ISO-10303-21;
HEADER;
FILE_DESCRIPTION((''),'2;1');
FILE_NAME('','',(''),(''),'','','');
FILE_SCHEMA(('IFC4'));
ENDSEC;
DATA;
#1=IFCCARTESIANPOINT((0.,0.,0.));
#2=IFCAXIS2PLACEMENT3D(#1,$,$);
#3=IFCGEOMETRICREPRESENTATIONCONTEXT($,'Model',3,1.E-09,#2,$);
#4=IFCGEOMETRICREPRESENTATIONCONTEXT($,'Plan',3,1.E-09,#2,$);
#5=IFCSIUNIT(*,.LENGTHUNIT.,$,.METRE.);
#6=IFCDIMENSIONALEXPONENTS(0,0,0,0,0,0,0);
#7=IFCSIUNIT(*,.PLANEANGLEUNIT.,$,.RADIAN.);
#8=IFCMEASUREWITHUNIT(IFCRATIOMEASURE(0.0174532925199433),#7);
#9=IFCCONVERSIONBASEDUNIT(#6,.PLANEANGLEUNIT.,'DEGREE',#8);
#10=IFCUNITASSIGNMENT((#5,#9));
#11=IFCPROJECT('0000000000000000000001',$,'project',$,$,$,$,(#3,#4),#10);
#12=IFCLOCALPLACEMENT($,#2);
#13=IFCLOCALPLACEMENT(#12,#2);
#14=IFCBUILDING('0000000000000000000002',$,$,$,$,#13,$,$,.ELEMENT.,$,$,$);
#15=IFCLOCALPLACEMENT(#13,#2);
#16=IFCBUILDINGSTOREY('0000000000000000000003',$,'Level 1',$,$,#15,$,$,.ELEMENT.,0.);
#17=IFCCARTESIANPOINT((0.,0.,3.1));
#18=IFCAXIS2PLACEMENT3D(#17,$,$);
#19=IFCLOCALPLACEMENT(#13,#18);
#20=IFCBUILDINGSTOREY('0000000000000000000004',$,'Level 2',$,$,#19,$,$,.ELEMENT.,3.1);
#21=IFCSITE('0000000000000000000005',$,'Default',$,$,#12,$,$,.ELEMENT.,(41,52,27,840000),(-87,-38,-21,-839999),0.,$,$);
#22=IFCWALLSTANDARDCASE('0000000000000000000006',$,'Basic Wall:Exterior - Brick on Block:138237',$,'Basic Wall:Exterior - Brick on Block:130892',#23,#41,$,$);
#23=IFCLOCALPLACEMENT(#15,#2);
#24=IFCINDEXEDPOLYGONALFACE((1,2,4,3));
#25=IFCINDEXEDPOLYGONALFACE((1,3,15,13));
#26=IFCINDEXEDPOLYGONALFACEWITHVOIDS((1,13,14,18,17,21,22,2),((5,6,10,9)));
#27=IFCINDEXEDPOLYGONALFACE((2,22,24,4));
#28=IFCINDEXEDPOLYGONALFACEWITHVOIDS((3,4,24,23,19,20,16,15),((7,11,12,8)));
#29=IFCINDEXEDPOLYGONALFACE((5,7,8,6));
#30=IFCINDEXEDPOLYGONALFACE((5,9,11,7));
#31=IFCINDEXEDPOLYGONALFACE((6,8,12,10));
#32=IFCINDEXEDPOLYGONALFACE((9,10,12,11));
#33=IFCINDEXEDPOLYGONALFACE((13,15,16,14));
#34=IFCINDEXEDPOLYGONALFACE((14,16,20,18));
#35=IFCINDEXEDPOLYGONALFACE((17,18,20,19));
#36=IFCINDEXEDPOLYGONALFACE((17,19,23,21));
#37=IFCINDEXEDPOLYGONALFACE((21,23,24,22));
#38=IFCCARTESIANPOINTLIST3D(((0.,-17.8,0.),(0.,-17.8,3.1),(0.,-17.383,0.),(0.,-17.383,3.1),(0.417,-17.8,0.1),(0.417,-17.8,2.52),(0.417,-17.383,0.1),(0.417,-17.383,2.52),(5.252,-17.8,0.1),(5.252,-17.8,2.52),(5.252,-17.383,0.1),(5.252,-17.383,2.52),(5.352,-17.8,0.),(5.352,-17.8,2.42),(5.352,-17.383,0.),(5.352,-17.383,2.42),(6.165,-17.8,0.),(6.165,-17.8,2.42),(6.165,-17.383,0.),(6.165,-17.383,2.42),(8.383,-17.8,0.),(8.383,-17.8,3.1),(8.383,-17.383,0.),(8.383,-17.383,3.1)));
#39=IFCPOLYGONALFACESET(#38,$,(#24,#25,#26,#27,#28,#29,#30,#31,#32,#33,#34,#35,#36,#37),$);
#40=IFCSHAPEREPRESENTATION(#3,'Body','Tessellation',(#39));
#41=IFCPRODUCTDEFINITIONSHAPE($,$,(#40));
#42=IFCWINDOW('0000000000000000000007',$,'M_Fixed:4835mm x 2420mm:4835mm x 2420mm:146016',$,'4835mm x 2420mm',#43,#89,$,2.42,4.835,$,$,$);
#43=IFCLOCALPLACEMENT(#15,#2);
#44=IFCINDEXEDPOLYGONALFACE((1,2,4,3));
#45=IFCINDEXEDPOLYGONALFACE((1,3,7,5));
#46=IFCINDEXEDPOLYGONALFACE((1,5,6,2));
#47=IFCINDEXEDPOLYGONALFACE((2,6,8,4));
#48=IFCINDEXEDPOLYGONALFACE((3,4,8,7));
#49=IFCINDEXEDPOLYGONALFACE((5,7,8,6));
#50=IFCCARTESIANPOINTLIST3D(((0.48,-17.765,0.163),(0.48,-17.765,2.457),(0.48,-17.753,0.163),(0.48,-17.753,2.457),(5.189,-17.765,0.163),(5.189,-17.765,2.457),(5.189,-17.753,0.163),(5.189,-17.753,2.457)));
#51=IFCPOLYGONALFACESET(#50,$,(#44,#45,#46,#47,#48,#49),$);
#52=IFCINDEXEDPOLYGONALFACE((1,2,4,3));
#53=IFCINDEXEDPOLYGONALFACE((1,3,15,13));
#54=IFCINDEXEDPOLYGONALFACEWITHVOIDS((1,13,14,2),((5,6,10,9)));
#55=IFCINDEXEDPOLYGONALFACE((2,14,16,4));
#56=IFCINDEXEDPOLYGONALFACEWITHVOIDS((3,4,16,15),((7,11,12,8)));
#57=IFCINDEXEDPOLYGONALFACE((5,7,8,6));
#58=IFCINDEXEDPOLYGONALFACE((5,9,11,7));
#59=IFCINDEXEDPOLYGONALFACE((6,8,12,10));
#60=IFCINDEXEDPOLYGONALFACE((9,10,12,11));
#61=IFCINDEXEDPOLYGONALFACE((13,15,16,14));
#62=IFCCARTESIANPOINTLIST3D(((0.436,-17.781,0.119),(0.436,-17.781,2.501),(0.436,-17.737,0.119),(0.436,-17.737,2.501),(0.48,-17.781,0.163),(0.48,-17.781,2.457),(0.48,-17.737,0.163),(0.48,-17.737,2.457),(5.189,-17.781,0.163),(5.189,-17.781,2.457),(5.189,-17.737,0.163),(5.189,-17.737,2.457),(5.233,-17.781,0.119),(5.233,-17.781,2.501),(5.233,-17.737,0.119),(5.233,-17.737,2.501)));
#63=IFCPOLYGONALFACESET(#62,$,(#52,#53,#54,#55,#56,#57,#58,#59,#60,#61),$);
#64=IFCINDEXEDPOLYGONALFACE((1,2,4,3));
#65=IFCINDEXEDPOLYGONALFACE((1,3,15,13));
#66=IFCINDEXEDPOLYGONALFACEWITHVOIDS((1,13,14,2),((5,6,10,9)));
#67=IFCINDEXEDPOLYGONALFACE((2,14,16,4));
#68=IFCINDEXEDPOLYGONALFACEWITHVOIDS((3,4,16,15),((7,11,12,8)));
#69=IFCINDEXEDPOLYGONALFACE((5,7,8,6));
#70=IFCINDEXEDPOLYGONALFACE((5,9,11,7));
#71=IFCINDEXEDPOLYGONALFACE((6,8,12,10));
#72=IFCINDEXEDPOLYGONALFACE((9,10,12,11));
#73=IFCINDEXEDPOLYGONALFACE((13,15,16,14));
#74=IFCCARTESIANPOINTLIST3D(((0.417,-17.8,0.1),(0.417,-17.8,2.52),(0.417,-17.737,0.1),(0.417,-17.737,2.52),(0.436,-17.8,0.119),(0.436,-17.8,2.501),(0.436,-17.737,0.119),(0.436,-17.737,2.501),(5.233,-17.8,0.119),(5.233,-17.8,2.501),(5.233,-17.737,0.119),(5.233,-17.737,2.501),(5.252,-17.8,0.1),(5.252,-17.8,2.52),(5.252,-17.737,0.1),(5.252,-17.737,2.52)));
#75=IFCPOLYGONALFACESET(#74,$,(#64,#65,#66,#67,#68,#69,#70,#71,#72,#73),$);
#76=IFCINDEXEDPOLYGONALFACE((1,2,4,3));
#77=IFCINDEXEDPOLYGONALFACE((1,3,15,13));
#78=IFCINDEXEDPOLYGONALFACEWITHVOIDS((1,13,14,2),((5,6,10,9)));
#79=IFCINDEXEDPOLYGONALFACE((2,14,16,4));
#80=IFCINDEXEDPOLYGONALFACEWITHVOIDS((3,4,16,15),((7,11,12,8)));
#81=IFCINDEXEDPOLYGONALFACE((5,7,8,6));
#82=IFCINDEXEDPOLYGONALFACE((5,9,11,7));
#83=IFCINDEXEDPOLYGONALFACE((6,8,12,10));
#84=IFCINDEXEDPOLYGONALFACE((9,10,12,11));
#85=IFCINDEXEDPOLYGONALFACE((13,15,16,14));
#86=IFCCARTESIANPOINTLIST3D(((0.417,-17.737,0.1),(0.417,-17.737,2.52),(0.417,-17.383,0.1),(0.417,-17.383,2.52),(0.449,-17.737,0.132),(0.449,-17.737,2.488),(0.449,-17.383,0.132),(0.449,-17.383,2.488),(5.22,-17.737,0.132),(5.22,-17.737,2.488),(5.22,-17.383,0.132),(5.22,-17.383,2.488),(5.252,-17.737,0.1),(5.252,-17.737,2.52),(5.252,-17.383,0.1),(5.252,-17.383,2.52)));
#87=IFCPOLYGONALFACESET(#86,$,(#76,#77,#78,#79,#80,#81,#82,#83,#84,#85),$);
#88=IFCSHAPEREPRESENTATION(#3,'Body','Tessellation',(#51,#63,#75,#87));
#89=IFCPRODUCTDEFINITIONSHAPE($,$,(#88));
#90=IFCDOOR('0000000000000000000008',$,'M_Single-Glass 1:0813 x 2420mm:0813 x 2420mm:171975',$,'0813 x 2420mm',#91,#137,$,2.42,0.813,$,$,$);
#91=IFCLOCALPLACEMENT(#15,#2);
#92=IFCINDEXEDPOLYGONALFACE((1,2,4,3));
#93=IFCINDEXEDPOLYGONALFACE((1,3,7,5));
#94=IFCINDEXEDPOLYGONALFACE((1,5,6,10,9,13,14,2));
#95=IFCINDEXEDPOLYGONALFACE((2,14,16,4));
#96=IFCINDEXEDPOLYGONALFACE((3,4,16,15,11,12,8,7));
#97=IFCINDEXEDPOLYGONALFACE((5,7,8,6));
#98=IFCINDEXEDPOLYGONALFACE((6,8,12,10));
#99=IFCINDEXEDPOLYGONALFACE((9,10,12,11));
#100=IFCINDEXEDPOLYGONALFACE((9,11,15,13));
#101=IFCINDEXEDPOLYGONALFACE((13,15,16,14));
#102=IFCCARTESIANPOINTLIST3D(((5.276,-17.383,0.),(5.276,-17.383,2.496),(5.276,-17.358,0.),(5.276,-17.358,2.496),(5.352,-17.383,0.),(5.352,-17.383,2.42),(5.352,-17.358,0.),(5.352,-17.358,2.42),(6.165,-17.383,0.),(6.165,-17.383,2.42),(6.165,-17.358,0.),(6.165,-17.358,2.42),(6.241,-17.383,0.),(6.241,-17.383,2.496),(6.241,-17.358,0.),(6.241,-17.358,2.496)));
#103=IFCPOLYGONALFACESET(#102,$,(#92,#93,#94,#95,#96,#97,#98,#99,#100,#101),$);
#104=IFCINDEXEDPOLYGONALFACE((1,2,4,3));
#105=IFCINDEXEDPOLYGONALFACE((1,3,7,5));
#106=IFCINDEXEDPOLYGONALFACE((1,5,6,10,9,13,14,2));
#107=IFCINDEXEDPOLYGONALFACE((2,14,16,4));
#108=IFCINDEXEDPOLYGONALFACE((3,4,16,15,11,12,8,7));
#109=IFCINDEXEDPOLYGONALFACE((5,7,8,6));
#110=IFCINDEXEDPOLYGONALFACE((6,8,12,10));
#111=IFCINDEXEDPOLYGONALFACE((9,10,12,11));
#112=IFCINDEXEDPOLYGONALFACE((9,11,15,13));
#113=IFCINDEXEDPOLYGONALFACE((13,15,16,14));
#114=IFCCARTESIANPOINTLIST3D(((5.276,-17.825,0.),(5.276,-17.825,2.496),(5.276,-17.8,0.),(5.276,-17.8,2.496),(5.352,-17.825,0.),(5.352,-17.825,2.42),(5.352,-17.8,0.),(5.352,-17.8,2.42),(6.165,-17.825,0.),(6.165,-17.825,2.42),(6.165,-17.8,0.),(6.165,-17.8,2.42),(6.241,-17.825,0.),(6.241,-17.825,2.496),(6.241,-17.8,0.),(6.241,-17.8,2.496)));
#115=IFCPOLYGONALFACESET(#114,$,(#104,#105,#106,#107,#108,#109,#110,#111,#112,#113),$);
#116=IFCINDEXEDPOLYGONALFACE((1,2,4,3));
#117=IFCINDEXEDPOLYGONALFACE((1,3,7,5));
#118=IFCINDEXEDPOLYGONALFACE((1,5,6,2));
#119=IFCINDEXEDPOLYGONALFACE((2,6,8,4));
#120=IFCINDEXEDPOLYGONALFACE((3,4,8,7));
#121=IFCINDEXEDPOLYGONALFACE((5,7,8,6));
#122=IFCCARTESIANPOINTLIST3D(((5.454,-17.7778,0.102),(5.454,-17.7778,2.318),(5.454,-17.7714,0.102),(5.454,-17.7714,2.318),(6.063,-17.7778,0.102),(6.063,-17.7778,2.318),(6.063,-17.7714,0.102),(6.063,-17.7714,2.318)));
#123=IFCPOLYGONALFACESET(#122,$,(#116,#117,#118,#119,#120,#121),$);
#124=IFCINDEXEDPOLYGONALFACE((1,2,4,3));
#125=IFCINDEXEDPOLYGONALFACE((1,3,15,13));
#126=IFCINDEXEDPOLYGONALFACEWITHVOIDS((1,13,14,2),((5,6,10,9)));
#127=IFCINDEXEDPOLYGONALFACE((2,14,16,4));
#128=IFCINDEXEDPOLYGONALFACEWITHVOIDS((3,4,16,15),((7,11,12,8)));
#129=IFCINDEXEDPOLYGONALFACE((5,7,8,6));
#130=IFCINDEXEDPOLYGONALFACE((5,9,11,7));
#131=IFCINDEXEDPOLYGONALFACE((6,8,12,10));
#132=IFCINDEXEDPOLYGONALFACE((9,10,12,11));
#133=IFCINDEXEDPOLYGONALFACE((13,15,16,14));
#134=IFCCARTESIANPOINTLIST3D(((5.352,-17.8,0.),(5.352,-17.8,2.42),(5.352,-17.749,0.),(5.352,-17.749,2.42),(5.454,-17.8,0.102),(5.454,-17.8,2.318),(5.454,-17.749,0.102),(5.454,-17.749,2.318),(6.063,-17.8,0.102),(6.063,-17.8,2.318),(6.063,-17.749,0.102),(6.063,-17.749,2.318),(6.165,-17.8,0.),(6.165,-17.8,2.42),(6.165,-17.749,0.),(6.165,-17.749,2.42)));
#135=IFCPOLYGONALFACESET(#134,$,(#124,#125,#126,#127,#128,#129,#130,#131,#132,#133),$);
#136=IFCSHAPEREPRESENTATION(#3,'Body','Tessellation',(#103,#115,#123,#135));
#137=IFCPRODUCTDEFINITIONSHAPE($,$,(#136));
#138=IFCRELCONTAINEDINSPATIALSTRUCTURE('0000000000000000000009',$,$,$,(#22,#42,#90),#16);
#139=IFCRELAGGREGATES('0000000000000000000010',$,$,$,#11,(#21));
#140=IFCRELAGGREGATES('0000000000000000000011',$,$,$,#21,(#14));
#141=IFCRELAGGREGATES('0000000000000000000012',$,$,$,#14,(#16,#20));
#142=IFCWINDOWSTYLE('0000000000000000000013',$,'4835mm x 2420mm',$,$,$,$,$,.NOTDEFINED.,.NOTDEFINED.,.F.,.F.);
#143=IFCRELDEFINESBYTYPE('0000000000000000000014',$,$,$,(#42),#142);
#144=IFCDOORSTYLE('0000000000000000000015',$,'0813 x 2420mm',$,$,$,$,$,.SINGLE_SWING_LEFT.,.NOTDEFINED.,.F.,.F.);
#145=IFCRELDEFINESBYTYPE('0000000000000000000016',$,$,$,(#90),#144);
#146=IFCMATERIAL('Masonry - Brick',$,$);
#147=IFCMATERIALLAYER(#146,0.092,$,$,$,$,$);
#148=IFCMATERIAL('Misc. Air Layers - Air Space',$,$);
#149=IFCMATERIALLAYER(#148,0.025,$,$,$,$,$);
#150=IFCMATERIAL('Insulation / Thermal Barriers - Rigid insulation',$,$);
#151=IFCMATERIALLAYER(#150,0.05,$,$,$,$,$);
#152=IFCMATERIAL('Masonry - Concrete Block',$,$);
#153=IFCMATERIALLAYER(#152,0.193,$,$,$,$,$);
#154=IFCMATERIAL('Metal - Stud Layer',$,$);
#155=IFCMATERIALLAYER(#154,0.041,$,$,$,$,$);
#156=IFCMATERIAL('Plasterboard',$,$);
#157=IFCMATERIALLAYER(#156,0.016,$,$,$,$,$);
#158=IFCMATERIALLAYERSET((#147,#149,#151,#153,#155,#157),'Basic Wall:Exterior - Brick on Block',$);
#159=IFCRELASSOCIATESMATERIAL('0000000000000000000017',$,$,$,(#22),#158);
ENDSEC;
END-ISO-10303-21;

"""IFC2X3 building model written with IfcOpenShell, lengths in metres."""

from ifc_helpers import new_model, entity, si_unit, converted_unit, frame, frame_2d, origin, origin_2d_with_axis, place, context, project, spatial, polyline, rectangle, outline, extrude, source, transform, mapped, material, layer, layer_set, layer_usage, type_object, type_shapes, element, fill, save


model = new_model("IFC2X3")

# Units and contexts
model_context = context("Model", 3, precision=1e-09, world=origin())
plan_context = context("Plan", 3, precision=1e-09, world=origin())
ifc_project = project(units=[si_unit("LENGTHUNIT", "METRE"), converted_unit("PLANEANGLEUNIT", "DEGREE", entity("IfcRatioMeasure", 0.0174532925199433), si_unit("PLANEANGLEUNIT", "RADIAN"), dimensions=[0, 0, 0, 0, 0, 0, 0])], contexts=[model_context, plan_context])

# Site, building, storey
site_placement = place(None, origin())
site = spatial("IfcSite", under=ifc_project, at=site_placement, Name="Default", CompositionType="ELEMENT", RefLatitude=(41, 52, 27, 840000), RefLongitude=(-87, -38, -21, -839999), RefElevation=0.0)
building_placement = place(site_placement, origin())
building = spatial("IfcBuilding", under=site, at=building_placement, CompositionType="ELEMENT")
storey_1_placement = place(building_placement, origin())
storey_1 = spatial("IfcBuildingStorey", under=building, at=storey_1_placement, Name="Level 1", CompositionType="ELEMENT", Elevation=0.0)

# Wall, openings, window, door
ifc_material_1 = material(Name="Masonry - Brick")
ifc_layer_1 = layer(ifc_material_1, 0.092)
ifc_material_2 = material(Name="Misc. Air Layers - Air Space")
ifc_layer_2 = layer(ifc_material_2, 0.025)
ifc_material_3 = material(Name="Insulation / Thermal Barriers - Rigid insulation")
ifc_layer_3 = layer(ifc_material_3, 0.05)
ifc_material_4 = material(Name="Masonry - Concrete Block")
ifc_layer_4 = layer(ifc_material_4, 0.193)
ifc_material_5 = material(Name="Metal - Stud Layer")
ifc_layer_5 = layer(ifc_material_5, 0.041)
ifc_material_6 = material(Name="Plasterboard")
ifc_layer_6 = layer(ifc_material_6, 0.016)
ifc_layer_set_1 = layer_set([ifc_layer_1, ifc_layer_2, ifc_layer_3, ifc_layer_4, ifc_layer_5, ifc_layer_6], Name="Basic Wall:Exterior - Brick on Block")
ifc_layer_usage_1 = layer_usage(ifc_layer_set_1, "AXIS2", "NEGATIVE", 0.2085)
wall_1_placement = place(storey_1_placement, frame((8.383, -17.5915, 0.0), z_axis=(0.0, 0.0, 1.0), x_axis=(-1.0, 0.0, 0.0)))
wall_1 = element("IfcWallStandardCase", 1, at=wall_1_placement, inside=storey_1, material=ifc_layer_usage_1, Name="Basic Wall:Exterior - Brick on Block:138237", ObjectType="Basic Wall:Exterior - Brick on Block:130892", context=model_context, shape_type="SweptSolid", body=[
    extrude(rectangle(XDim=8.383, YDim=0.417, at=frame_2d((4.1915, 0.0), x_axis=(-1.0, 0.0))), origin(), (0.0, 0.0, 1.0), 3.1),
])
opening_1_placement = place(wall_1_placement, frame((3.131, -0.2085, 0.1)))
opening_1 = element("IfcOpeningElement", 2, at=opening_1_placement, cuts=wall_1, ObjectType="Opening", context=model_context, shape_type="SweptSolid", body=[
    extrude(rectangle(XDim=2.42, YDim=4.835, at=frame_2d((1.21, 2.4175), x_axis=(1.0, 0.0))), frame((0.0, 0.0, 0.0), z_axis=(0.0, 1.0, 0.0), x_axis=(0.0, 0.0, 1.0)), (0.0, 0.0, 1.0), 0.417),
])
opening_2_placement = place(wall_1_placement, frame((2.218, -0.2085, 0.0)))
opening_2 = element("IfcOpeningElement", 3, at=opening_2_placement, cuts=wall_1, ObjectType="Opening", context=model_context, shape_type="SweptSolid", body=[
    extrude(rectangle(XDim=0.813, YDim=2.42, at=frame_2d((1.21, 0.4065), x_axis=(0.0, -1.0))), frame((0.0, 0.0, 0.0), z_axis=(0.0, 1.0, 0.0), x_axis=(0.0, 0.0, 1.0)), (0.0, 0.0, 1.0), 0.417),
])
window_style_1 = type_object("IfcWindowStyle", Name="4835mm x 2420mm", ConstructionType="NOTDEFINED", OperationType="NOTDEFINED", ParameterTakesPrecedence=False, Sizeable=False)
shared_shape_1 = source(origin(), model_context, "Body", "SweptSolid", [
    extrude(rectangle(XDim=0.012, YDim=4.709, at=origin_2d_with_axis()), frame((2.4175, 0.376, 0.063), z_axis=(0.0, 0.0, 1.0), x_axis=(0.0, -1.0, 0.0)), (0.0, 0.0, 1.0), 2.294),
    extrude(outline(polyline([(-2.3985, -1.191), (2.3985, -1.191), (2.3985, 1.191), (-2.3985, 1.191), (-2.3985, -1.191)]), holes=[polyline([(-2.3545, -1.147), (-2.3545, 1.147), (2.3545, 1.147), (2.3545, -1.147), (-2.3545, -1.147)])]), frame((2.4175, 0.354, 1.21), z_axis=(0.0, 1.0, 0.0), x_axis=(1.0, 0.0, 0.0)), (0.0, 0.0, 1.0), 0.044),
    extrude(outline(polyline([(-2.4175, -1.21), (2.4175, -1.21), (2.4175, 1.21), (-2.4175, 1.21), (-2.4175, -1.21)]), holes=[polyline([(-2.3985, -1.191), (-2.3985, 1.191), (2.3985, 1.191), (2.3985, -1.191), (-2.3985, -1.191)])]), frame((2.4175, 0.354, 1.21), z_axis=(0.0, 1.0, 0.0), x_axis=(1.0, 0.0, 0.0)), (0.0, 0.0, 1.0), 0.063),
    extrude(outline(polyline([(-2.4175, -1.21), (2.4175, -1.21), (2.4175, 1.21), (-2.4175, 1.21), (-2.4175, -1.21)]), holes=[polyline([(-2.3855, -1.178), (-2.3855, 1.178), (2.3855, 1.178), (2.3855, -1.178), (-2.3855, -1.178)])]), frame((2.4175, 0.0, 1.21), z_axis=(0.0, 1.0, 0.0), x_axis=(1.0, 0.0, 0.0)), (0.0, 0.0, 1.0), 0.354),
])
type_shapes(window_style_1, [shared_shape_1])
window_1_placement = place(opening_1_placement, origin())
window_1 = element("IfcWindow", 4, at=window_1_placement, inside=storey_1, type_object=window_style_1, Name="M_Fixed:4835mm x 2420mm:4835mm x 2420mm:146016", ObjectType="4835mm x 2420mm", OverallHeight=2.42, OverallWidth=4.835, context=model_context, shape_type="MappedRepresentation", body=[
    mapped(shared_shape_1, transform((0.0, 0.0, 0.0), scale=1.0)),
])
fill(opening_1, window_1)
door_style_1 = type_object("IfcDoorStyle", Name="0813 x 2420mm", ConstructionType="NOTDEFINED", OperationType="SINGLE_SWING_LEFT", ParameterTakesPrecedence=False, Sizeable=False)
shared_shape_2 = source(origin(), model_context, "Body", "SweptSolid", [
    extrude(outline(polyline([(-0.4065, -1.191), (-0.4065, 1.229), (-0.4825, 1.229), (-0.4825, -1.267), (0.4825, -1.267), (0.4825, 1.229), (0.4065, 1.229), (0.4065, -1.191), (-0.4065, -1.191)])), frame((0.4065, 0.0, 1.229), z_axis=(0.0, 1.0, 0.0), x_axis=(1.0, 0.0, 0.0)), (0.0, 0.0, -1.0), 0.025),
    extrude(outline(polyline([(-0.4065, -1.191), (-0.4065, 1.229), (-0.4825, 1.229), (-0.4825, -1.267), (0.4825, -1.267), (0.4825, 1.229), (0.4065, 1.229), (0.4065, -1.191), (-0.4065, -1.191)])), frame((0.4065, 0.442, 1.229), z_axis=(0.0, 1.0, 0.0), x_axis=(1.0, 0.0, 0.0)), (0.0, 0.0, -1.0), 0.025),
    extrude(rectangle(XDim=0.609, YDim=0.0064, at=origin_2d_with_axis()), frame((0.4065, 0.3916, 0.102)), (0.0, 0.0, 1.0), 2.216),
    extrude(outline(polyline([(-1.21, -0.4065), (1.21, -0.4065), (1.21, 0.4065), (-1.21, 0.4065), (-1.21, -0.4065)]), holes=[polyline([(-1.108, 0.3045), (1.108, 0.3045), (1.108, -0.3045), (-1.108, -0.3045), (-1.108, 0.3045)])]), frame((0.4065, 0.417, 1.21), z_axis=(0.0, -1.0, 0.0), x_axis=(0.0, 0.0, -1.0)), (0.0, 0.0, 1.0), 0.051),
])
type_shapes(door_style_1, [shared_shape_2])
door_1_placement = place(opening_2_placement, origin())
door_1 = element("IfcDoor", 5, at=door_1_placement, inside=storey_1, type_object=door_style_1, Name="M_Single-Glass 1:0813 x 2420mm:0813 x 2420mm:171975", ObjectType="0813 x 2420mm", OverallHeight=2.42, OverallWidth=0.813, context=model_context, shape_type="MappedRepresentation", body=[
    mapped(shared_shape_2, transform((0.0, 0.0, 0.0), scale=1.0)),
])
fill(opening_2, door_1)

# Shared definitions
storey_2_placement = place(building_placement, frame((0.0, 0.0, 3.1)))
storey_2 = spatial("IfcBuildingStorey", under=building, at=storey_2_placement, Name="Level 2", CompositionType="ELEMENT", Elevation=3.1)

save(model, "model.ifc")
